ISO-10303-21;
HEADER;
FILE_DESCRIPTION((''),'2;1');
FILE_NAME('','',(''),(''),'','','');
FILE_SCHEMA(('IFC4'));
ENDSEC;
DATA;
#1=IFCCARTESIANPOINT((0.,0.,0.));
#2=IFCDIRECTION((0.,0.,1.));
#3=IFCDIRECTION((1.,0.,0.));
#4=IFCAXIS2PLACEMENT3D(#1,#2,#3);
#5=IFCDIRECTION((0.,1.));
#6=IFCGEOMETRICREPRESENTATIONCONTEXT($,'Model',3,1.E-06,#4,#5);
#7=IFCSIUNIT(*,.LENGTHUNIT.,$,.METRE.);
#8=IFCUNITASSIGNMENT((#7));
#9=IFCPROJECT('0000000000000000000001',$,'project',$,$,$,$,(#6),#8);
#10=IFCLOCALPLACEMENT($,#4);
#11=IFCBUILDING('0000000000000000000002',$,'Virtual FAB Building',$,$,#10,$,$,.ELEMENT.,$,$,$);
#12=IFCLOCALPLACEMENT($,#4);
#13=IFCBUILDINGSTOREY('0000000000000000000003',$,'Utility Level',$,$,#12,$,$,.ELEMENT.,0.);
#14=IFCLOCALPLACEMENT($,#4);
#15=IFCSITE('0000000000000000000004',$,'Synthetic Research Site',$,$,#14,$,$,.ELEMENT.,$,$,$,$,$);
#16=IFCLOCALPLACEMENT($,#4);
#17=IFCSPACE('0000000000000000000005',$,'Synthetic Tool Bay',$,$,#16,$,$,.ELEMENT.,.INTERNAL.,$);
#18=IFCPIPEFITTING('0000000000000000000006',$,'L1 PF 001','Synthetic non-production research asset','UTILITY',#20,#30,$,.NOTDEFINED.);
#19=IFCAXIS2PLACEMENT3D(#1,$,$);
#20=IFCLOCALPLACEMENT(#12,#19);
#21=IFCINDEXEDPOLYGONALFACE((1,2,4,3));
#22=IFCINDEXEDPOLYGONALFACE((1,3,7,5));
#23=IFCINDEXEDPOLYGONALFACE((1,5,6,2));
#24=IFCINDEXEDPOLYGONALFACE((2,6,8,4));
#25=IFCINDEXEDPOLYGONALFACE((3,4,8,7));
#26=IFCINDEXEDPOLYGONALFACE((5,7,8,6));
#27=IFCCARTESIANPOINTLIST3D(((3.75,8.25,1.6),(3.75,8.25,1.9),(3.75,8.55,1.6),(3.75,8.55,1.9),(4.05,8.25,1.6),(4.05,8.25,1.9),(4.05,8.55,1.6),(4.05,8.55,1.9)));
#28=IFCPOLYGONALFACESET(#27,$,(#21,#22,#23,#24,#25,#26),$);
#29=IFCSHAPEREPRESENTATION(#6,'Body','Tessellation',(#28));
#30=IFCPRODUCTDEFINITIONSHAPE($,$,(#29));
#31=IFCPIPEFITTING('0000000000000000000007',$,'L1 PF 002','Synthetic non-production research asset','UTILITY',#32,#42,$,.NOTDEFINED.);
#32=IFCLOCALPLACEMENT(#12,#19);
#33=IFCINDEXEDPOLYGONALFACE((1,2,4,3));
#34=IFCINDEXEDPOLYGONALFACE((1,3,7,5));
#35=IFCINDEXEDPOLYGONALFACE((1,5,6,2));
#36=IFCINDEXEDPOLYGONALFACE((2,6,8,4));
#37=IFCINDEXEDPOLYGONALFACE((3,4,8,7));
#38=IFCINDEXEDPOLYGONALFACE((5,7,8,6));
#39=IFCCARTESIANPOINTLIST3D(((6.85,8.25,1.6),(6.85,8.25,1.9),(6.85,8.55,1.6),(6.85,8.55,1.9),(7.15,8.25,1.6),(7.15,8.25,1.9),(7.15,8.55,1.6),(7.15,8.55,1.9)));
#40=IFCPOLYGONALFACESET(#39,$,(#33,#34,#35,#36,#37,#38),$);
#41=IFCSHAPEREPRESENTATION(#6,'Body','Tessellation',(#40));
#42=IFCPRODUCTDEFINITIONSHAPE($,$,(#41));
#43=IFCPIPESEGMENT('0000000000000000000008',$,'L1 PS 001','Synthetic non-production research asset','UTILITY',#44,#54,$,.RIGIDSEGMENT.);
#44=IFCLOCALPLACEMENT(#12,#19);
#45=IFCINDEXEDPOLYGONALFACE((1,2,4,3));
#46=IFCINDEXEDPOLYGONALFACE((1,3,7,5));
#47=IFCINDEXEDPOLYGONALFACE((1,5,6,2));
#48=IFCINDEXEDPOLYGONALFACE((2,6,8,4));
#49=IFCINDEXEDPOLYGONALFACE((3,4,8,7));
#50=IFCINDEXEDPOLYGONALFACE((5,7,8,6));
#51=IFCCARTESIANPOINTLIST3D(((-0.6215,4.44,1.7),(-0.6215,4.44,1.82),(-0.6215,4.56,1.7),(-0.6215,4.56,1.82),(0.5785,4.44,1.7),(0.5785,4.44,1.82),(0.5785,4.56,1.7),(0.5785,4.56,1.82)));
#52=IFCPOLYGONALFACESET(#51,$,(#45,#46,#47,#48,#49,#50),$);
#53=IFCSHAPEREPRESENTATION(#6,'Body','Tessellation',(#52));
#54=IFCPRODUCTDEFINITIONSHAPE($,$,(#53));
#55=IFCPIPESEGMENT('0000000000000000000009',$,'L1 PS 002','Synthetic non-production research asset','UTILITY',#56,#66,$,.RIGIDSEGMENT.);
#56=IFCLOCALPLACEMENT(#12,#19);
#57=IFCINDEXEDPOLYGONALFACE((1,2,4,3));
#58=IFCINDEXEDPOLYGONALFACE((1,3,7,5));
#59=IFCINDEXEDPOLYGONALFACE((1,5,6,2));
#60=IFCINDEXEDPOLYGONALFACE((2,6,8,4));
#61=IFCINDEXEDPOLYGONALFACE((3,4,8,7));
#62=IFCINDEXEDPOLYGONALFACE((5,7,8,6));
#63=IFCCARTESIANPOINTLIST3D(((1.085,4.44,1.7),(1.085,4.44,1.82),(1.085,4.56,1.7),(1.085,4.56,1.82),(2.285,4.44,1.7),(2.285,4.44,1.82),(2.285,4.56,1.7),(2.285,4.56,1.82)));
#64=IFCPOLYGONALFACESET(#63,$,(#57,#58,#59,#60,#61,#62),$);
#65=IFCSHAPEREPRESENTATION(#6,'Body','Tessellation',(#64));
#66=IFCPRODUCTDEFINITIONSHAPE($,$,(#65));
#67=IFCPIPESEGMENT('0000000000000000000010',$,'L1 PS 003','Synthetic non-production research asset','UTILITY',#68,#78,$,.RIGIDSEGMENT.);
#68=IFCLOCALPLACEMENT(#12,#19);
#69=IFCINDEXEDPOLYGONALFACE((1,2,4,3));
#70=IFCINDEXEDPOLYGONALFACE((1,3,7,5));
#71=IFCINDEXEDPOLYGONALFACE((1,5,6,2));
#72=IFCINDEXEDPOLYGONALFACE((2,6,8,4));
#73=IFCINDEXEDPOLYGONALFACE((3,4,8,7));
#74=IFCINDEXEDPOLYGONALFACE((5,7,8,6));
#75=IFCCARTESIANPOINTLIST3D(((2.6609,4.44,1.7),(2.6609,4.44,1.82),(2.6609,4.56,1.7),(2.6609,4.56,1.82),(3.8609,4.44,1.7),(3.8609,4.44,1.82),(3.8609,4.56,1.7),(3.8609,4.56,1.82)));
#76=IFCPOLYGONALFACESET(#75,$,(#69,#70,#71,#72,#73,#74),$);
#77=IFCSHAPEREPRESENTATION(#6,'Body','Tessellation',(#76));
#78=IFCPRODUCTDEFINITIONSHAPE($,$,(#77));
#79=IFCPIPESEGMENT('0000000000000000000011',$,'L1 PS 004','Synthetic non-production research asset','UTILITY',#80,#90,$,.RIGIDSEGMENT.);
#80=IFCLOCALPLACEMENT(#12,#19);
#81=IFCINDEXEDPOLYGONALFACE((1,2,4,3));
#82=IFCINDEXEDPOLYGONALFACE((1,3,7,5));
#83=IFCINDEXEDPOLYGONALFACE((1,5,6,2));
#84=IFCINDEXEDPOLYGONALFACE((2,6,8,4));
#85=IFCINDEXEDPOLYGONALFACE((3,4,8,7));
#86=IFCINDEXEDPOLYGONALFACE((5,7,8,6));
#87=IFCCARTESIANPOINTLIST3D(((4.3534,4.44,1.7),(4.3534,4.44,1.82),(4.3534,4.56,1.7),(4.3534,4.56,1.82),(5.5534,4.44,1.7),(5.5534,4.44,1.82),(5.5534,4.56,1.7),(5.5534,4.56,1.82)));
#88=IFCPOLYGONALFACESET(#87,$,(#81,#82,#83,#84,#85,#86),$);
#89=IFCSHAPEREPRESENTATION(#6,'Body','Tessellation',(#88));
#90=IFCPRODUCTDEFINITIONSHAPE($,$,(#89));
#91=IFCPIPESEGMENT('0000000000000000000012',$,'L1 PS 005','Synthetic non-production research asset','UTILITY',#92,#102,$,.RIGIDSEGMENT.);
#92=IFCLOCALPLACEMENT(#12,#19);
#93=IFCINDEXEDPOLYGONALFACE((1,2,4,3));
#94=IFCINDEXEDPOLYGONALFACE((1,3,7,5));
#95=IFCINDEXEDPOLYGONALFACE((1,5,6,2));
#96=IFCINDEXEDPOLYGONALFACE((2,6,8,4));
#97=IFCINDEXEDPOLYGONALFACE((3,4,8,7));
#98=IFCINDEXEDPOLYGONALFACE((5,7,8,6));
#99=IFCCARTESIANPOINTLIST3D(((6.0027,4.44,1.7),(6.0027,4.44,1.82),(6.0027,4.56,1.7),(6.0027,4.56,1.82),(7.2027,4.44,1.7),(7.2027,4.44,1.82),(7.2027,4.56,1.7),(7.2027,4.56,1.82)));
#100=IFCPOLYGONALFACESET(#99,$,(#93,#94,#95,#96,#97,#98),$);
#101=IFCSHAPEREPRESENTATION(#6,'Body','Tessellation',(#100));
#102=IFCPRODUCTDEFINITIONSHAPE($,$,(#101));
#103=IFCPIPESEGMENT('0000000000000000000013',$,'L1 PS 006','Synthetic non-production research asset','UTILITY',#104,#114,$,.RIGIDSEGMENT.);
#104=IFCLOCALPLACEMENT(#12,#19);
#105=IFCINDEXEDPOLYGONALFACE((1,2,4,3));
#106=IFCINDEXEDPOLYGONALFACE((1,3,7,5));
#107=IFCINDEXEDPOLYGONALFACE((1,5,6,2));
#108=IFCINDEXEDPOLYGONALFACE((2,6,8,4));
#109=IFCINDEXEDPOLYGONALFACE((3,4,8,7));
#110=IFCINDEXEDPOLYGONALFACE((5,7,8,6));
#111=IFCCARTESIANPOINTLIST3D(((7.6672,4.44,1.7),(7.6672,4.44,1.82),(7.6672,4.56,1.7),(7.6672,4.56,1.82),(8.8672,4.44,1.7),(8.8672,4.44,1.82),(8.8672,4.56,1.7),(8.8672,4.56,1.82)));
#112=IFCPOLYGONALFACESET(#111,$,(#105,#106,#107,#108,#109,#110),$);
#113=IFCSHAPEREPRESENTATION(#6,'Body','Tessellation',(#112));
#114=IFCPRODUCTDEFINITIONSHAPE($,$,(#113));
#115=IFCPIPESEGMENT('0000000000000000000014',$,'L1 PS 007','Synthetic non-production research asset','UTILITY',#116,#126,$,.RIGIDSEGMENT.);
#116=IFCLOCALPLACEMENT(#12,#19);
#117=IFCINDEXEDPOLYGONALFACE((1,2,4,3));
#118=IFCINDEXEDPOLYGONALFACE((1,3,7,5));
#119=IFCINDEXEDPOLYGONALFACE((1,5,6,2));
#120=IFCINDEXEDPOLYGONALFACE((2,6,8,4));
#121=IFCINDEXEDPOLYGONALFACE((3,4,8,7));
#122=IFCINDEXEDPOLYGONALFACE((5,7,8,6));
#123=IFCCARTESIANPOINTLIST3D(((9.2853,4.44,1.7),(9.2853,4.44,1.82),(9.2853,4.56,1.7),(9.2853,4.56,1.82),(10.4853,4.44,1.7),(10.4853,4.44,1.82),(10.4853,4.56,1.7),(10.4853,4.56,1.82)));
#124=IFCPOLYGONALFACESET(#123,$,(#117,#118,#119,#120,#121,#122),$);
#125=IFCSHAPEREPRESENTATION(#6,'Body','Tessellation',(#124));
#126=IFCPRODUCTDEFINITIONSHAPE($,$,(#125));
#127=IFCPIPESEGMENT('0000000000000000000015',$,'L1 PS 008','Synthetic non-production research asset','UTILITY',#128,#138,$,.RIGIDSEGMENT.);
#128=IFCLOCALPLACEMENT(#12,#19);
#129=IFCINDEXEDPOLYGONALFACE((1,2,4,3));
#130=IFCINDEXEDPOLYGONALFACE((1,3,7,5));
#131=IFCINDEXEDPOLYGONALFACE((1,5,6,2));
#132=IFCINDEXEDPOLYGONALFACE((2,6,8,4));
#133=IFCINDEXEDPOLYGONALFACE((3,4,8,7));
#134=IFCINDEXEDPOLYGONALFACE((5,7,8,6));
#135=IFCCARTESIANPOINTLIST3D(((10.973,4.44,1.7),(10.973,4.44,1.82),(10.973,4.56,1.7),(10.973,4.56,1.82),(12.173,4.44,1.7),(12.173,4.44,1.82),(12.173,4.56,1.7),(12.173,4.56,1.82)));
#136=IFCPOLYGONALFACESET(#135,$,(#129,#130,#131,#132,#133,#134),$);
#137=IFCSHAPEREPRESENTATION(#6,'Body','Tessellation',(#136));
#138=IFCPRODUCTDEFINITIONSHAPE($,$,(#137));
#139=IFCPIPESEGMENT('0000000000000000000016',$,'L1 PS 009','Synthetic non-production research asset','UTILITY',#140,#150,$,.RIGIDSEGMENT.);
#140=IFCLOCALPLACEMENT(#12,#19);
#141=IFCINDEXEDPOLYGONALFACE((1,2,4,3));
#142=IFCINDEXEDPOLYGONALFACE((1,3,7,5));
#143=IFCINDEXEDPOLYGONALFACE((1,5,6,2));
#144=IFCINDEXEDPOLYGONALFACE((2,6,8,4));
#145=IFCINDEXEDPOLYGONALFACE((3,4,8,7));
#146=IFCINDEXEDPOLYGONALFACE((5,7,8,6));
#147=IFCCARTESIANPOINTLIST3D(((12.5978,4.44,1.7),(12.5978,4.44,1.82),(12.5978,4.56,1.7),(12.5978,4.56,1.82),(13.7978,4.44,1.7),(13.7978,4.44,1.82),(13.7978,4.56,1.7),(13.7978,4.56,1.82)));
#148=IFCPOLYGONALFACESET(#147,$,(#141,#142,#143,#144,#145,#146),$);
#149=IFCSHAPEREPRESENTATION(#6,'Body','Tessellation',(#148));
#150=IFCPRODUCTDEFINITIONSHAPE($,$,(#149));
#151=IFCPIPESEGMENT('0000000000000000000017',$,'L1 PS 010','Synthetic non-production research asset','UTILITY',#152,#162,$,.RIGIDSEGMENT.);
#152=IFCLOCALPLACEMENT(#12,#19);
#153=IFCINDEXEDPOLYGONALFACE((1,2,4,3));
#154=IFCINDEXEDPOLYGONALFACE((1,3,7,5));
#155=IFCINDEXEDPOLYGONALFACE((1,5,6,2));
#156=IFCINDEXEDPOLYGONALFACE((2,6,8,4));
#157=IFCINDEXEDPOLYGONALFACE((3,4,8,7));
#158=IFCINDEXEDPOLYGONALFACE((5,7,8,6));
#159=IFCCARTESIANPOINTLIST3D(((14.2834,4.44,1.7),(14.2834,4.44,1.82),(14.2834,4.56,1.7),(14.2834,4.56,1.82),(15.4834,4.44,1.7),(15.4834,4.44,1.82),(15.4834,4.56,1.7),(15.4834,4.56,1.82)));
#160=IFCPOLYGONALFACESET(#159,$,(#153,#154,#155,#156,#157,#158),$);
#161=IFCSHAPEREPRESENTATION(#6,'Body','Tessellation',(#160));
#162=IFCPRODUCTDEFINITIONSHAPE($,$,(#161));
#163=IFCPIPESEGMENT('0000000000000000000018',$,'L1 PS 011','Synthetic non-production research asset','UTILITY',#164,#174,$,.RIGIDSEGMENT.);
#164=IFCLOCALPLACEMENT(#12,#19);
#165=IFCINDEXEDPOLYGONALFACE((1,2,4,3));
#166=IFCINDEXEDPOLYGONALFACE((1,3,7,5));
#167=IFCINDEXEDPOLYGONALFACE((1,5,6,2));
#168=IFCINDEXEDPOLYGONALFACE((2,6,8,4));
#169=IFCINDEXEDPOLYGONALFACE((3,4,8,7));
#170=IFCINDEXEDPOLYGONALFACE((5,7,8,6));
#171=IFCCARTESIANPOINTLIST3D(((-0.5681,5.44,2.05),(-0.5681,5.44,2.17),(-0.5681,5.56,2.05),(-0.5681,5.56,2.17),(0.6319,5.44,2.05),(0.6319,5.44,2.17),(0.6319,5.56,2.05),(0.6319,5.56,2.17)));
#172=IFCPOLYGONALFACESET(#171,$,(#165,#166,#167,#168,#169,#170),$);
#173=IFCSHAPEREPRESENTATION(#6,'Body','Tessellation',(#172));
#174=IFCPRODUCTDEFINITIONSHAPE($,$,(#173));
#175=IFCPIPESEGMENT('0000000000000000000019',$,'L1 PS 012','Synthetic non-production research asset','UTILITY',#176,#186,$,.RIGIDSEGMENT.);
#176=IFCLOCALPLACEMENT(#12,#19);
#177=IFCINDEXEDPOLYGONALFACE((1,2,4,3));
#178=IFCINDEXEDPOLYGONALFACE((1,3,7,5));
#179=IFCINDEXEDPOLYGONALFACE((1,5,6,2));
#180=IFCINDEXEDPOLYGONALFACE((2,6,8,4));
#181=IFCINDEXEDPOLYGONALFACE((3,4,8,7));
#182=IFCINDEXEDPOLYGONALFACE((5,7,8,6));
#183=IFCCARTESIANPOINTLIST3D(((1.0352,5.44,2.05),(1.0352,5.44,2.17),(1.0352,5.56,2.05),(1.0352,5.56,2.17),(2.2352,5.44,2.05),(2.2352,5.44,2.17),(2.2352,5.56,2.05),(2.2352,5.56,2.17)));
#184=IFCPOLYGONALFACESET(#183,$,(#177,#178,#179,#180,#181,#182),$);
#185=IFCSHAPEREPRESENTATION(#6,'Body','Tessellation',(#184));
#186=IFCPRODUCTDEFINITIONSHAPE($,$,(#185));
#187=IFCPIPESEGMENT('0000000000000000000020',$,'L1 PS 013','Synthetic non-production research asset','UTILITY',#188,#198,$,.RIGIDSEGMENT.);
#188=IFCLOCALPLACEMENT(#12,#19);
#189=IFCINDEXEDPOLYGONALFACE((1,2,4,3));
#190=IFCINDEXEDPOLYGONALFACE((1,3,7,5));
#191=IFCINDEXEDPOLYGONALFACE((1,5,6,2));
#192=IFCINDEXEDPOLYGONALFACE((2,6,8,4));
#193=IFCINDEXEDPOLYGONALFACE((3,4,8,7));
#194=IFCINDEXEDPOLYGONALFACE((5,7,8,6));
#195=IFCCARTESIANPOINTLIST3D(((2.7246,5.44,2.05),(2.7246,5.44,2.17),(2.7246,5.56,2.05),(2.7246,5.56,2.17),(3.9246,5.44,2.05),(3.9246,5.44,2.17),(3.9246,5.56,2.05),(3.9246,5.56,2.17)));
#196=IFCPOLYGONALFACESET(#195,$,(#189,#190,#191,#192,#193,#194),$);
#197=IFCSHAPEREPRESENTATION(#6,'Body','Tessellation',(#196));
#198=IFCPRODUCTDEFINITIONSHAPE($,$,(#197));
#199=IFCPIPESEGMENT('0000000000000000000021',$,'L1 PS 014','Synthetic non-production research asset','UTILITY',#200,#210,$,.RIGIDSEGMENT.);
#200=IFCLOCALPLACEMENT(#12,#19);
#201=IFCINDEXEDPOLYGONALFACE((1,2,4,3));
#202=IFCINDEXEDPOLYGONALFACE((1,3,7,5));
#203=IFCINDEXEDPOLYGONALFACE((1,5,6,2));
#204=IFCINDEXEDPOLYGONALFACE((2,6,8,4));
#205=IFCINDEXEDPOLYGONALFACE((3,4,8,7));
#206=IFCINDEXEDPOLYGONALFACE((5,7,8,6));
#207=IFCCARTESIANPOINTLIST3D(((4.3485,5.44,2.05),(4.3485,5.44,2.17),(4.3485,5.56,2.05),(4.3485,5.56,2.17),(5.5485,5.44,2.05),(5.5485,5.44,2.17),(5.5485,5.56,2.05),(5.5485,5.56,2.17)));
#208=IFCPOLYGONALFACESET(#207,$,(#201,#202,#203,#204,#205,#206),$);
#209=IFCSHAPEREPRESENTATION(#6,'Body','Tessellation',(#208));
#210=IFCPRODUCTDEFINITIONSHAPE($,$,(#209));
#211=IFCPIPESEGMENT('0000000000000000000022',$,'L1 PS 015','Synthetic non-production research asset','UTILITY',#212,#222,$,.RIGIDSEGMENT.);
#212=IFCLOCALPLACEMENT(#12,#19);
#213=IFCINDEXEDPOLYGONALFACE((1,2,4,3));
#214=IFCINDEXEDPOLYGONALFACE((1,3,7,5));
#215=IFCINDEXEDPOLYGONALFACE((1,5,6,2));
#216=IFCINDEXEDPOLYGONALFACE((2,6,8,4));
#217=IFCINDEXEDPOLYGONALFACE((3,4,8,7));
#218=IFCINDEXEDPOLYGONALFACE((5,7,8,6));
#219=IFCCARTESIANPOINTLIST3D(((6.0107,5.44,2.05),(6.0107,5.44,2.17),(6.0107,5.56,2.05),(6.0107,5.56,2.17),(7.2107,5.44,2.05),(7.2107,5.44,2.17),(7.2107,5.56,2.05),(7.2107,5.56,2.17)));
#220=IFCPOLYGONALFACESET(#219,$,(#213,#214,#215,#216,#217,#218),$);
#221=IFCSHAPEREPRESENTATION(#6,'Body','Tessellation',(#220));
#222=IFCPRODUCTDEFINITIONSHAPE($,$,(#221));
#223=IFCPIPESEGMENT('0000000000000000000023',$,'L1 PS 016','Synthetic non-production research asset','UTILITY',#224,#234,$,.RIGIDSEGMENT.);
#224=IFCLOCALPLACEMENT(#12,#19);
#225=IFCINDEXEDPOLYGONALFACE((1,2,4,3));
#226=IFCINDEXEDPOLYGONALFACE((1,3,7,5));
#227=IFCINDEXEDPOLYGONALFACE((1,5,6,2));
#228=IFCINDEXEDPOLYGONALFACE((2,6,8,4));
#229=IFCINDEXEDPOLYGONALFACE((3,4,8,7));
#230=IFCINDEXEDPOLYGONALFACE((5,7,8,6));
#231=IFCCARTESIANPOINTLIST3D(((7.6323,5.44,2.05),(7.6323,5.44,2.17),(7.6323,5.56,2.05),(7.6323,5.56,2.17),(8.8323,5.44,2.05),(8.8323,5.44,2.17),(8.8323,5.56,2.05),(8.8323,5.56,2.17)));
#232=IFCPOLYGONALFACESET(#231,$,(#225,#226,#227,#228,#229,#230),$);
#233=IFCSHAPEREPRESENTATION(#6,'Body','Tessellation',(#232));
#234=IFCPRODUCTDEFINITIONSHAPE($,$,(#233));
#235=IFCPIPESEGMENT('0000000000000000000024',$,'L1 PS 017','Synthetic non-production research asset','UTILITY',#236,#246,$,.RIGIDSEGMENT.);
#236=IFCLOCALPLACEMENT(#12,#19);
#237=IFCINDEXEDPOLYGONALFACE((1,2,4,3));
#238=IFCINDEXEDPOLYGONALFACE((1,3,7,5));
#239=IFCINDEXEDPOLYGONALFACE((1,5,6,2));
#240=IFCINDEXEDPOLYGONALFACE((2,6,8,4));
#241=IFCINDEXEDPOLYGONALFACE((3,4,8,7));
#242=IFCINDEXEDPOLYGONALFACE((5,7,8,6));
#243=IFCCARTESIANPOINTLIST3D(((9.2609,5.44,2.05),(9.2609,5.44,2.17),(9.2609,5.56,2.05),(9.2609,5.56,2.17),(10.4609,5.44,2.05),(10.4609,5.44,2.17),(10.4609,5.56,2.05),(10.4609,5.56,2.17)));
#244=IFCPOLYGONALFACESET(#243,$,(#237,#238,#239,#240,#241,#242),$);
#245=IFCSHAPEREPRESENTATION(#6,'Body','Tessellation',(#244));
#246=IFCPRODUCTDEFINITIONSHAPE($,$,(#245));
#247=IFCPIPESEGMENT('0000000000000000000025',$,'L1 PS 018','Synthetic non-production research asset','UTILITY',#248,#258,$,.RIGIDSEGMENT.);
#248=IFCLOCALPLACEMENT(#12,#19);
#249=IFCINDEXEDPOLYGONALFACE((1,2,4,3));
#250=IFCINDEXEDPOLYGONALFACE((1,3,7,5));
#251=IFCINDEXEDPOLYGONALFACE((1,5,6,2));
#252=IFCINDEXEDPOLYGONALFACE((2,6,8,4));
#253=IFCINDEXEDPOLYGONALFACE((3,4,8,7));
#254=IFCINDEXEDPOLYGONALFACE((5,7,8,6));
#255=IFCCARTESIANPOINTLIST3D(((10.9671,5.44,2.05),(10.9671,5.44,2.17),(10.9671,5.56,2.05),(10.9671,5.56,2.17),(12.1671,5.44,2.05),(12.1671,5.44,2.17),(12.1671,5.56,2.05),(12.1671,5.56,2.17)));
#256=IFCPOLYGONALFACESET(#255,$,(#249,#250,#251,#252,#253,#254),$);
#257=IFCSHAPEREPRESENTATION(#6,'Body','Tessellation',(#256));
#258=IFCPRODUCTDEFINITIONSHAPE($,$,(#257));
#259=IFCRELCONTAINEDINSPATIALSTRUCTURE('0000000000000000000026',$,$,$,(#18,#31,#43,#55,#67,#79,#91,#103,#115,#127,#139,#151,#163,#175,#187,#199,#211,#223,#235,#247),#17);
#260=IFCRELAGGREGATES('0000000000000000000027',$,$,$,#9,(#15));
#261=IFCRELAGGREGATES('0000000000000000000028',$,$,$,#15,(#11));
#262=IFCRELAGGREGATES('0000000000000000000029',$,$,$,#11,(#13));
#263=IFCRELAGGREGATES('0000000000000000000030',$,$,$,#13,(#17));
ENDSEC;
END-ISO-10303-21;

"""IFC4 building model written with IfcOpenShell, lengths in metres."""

from ifc_helpers import new_model, si_unit, direction, frame, origin_with_axes, origin_2d_with_axis, place, context, project, spatial, rectangle, extrude, element, save


model = new_model("IFC4")

# Units and contexts
model_context = context("Model", 3, precision=1e-06, world=origin_with_axes(), true_north=direction((0.0, 1.0)))
ifc_project = project(units=[si_unit("LENGTHUNIT", "METRE")], contexts=[model_context])

# Site, building, storey, space
site_placement = place(None, origin_with_axes())
site = spatial("IfcSite", under=ifc_project, at=site_placement, Name="Synthetic Research Site", CompositionType="ELEMENT")
building_placement = place(None, origin_with_axes())
building = spatial("IfcBuilding", under=site, at=building_placement, Name="Virtual FAB Building", CompositionType="ELEMENT")
storey_placement = place(None, origin_with_axes())
storey = spatial("IfcBuildingStorey", under=building, at=storey_placement, Name="Utility Level", CompositionType="ELEMENT", Elevation=0.0)
space_placement = place(None, origin_with_axes())
space = spatial("IfcSpace", under=storey, at=space_placement, Name="Synthetic Tool Bay", CompositionType="ELEMENT", PredefinedType="INTERNAL")

# Pipe fittings
for number, where, z_axis, x_axis, name in (
    (1, (3.9, 8.4, 1.6), (0.0, 0.0, 1.0), (1.0, 0.0, 0.0), "L1 PF 001"),
    (2, (7.0, 8.4, 1.6), (0.0, 0.0, 1.0), (1.0, 0.0, 0.0), "L1 PF 002"),
):
    element("IfcPipeFitting", number, at=place(None, frame(where, z_axis=z_axis, x_axis=x_axis)), inside=space, Name=name, Description="Synthetic non-production research asset", ObjectType="UTILITY", PredefinedType="NOTDEFINED", context=model_context, shape_type="SweptSolid", body=[
        extrude(rectangle(XDim=0.3, YDim=0.3, at=origin_2d_with_axis()), origin_with_axes(), (0.0, 0.0, 1.0), 0.3),
    ])

# Pipe segments
for number, where, z_axis, x_axis, name in (
    (3, (-0.0215, 4.5, 1.7), (0.0, 0.0, 1.0), (1.0, 0.0, 0.0), "L1 PS 001"),
    (4, (1.685, 4.5, 1.7), (0.0, 0.0, 1.0), (1.0, 0.0, 0.0), "L1 PS 002"),
    (5, (3.2609, 4.5, 1.7), (0.0, 0.0, 1.0), (1.0, 0.0, 0.0), "L1 PS 003"),
    (6, (4.9534, 4.5, 1.7), (0.0, 0.0, 1.0), (1.0, 0.0, 0.0), "L1 PS 004"),
    (7, (6.6027, 4.5, 1.7), (0.0, 0.0, 1.0), (1.0, 0.0, 0.0), "L1 PS 005"),
    (8, (8.2672, 4.5, 1.7), (0.0, 0.0, 1.0), (1.0, 0.0, 0.0), "L1 PS 006"),
    (9, (9.8853, 4.5, 1.7), (0.0, 0.0, 1.0), (1.0, 0.0, 0.0), "L1 PS 007"),
    (10, (11.573, 4.5, 1.7), (0.0, 0.0, 1.0), (1.0, 0.0, 0.0), "L1 PS 008"),
    (11, (13.1978, 4.5, 1.7), (0.0, 0.0, 1.0), (1.0, 0.0, 0.0), "L1 PS 009"),
    (12, (14.8834, 4.5, 1.7), (0.0, 0.0, 1.0), (1.0, 0.0, 0.0), "L1 PS 010"),
    (13, (0.0319, 5.5, 2.05), (0.0, 0.0, 1.0), (1.0, 0.0, 0.0), "L1 PS 011"),
    (14, (1.6352, 5.5, 2.05), (0.0, 0.0, 1.0), (1.0, 0.0, 0.0), "L1 PS 012"),
    (15, (3.3246, 5.5, 2.05), (0.0, 0.0, 1.0), (1.0, 0.0, 0.0), "L1 PS 013"),
    (16, (4.9485, 5.5, 2.05), (0.0, 0.0, 1.0), (1.0, 0.0, 0.0), "L1 PS 014"),
    (17, (6.6107, 5.5, 2.05), (0.0, 0.0, 1.0), (1.0, 0.0, 0.0), "L1 PS 015"),
    (18, (8.2323, 5.5, 2.05), (0.0, 0.0, 1.0), (1.0, 0.0, 0.0), "L1 PS 016"),
    (19, (9.8609, 5.5, 2.05), (0.0, 0.0, 1.0), (1.0, 0.0, 0.0), "L1 PS 017"),
    (20, (11.5671, 5.5, 2.05), (0.0, 0.0, 1.0), (1.0, 0.0, 0.0), "L1 PS 018"),
):
    element("IfcPipeSegment", number, at=place(None, frame(where, z_axis=z_axis, x_axis=x_axis)), inside=space, Name=name, Description="Synthetic non-production research asset", ObjectType="UTILITY", PredefinedType="RIGIDSEGMENT", context=model_context, shape_type="SweptSolid", body=[
        extrude(rectangle(XDim=1.2, YDim=0.12, at=origin_2d_with_axis()), origin_with_axes(), (0.0, 0.0, 1.0), 0.12),
    ])

save(model, "model.ifc")
